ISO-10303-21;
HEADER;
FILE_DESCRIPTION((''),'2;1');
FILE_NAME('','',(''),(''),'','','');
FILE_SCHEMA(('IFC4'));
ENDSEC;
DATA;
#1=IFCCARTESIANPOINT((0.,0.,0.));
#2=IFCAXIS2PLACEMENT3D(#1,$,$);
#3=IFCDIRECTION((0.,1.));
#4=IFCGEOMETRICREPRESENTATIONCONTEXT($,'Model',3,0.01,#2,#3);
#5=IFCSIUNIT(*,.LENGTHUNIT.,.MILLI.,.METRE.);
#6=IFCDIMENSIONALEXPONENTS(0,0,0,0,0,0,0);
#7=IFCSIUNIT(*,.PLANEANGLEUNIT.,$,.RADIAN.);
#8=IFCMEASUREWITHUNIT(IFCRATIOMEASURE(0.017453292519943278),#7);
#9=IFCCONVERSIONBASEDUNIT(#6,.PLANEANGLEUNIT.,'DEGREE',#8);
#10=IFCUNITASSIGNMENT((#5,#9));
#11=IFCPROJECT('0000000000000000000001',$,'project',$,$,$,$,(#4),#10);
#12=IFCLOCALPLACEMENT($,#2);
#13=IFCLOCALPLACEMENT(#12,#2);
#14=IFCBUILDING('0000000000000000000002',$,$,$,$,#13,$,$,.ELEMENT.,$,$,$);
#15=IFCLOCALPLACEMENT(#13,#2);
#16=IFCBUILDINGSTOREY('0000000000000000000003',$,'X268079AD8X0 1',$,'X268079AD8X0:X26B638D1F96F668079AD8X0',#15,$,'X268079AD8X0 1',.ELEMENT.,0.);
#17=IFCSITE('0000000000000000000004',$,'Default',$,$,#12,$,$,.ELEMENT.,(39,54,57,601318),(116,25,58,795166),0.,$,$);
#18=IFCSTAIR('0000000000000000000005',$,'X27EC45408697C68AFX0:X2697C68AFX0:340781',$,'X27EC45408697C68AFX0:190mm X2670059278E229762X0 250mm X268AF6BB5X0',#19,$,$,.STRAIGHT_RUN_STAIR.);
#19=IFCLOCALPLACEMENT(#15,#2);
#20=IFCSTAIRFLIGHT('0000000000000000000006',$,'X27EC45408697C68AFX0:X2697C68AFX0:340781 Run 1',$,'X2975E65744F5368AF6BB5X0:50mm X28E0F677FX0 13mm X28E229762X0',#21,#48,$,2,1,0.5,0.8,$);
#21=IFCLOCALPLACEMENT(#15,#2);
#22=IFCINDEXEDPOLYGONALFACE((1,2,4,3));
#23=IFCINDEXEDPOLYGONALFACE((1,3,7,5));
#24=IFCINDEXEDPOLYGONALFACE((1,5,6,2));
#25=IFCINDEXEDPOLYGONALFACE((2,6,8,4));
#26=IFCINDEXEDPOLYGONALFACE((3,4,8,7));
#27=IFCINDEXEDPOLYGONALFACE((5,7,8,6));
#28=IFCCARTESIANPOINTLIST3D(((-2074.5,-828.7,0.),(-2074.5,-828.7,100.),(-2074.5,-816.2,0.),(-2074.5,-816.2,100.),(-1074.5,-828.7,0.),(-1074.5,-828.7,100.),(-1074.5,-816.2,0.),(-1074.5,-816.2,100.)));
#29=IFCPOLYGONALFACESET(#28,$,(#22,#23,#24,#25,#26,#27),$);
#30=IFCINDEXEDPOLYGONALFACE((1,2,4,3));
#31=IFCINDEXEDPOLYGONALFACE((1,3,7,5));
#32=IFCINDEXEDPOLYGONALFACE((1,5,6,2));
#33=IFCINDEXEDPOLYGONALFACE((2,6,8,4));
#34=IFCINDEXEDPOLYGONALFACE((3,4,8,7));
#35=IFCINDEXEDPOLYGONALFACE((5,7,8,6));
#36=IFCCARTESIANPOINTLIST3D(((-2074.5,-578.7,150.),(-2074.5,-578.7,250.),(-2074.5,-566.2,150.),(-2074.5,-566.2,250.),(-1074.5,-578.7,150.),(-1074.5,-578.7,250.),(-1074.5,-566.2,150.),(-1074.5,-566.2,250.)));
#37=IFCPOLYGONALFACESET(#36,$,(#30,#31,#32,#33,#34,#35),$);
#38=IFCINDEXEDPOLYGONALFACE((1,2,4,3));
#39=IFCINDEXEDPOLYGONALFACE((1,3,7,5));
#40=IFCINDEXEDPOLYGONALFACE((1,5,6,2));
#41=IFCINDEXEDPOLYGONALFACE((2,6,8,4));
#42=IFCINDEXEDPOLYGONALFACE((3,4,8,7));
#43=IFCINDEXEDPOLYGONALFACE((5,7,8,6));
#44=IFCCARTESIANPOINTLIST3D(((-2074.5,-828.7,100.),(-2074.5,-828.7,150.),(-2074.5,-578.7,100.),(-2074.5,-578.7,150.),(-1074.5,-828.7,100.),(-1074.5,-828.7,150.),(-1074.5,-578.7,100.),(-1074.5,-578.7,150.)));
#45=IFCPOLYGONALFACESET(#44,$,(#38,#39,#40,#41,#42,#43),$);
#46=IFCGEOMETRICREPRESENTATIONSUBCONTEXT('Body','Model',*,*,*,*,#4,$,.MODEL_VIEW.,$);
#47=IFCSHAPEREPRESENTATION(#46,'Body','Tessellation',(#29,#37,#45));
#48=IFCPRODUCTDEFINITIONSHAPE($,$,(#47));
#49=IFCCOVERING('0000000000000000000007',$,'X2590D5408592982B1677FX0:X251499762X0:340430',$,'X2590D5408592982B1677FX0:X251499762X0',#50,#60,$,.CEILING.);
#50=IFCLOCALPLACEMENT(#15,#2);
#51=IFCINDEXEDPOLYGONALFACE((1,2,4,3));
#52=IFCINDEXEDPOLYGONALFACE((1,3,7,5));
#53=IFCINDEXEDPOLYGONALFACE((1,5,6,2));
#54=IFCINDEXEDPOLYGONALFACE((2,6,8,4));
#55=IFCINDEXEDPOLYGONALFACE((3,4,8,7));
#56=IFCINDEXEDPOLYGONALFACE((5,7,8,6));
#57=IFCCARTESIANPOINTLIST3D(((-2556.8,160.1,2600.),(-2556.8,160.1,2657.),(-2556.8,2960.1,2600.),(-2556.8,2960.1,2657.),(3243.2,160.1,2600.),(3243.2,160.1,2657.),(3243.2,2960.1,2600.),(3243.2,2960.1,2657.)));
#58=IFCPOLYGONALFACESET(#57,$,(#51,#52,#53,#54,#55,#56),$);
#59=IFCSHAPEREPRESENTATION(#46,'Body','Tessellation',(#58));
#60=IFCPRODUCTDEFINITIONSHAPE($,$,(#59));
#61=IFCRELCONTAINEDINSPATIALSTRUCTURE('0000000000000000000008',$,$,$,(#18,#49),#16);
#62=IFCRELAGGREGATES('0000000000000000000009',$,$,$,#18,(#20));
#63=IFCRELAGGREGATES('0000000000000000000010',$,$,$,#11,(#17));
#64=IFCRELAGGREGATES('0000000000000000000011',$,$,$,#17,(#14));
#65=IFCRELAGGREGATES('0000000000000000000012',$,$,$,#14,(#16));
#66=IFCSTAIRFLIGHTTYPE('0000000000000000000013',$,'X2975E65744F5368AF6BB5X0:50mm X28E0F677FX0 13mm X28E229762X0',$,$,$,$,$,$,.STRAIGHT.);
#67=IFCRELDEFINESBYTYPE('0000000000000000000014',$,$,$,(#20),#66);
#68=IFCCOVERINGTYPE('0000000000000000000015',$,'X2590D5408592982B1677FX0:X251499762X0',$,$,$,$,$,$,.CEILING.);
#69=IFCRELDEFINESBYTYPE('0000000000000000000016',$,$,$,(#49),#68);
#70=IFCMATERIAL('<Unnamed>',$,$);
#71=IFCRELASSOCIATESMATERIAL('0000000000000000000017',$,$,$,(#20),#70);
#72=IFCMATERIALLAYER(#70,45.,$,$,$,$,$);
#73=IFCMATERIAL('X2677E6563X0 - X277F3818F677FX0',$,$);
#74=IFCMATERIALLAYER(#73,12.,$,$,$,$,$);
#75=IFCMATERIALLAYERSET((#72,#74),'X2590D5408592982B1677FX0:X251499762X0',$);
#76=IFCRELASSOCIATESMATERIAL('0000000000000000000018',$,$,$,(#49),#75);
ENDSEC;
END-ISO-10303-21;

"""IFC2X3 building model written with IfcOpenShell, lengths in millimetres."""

from ifc_helpers import new_model, entity, si_unit, converted_unit, direction, frame, frame_2d, origin, origin_2d_with_axis, place, context, subcontext, project, spatial, rectangle, extrude, material, layer, layer_set, layer_usage, type_object, element, aggregate, save


model = new_model("IFC2X3")

# Units and contexts
model_context = context("Model", 3, precision=0.01, world=origin(), true_north=direction((0.0, 1.0)))
body_context = subcontext(model_context, "Body", "Model", "MODEL_VIEW")
ifc_project = project(units=[si_unit("LENGTHUNIT", "METRE", prefix="MILLI"), converted_unit("PLANEANGLEUNIT", "DEGREE", entity("IfcRatioMeasure", 0.017453292519943278), si_unit("PLANEANGLEUNIT", "RADIAN"), dimensions=[0, 0, 0, 0, 0, 0, 0])], contexts=[model_context])

# Site, building, storey
site_placement = place(None, origin())
site = spatial("IfcSite", under=ifc_project, at=site_placement, Name="Default", CompositionType="ELEMENT", RefLatitude=(39, 54, 57, 601318), RefLongitude=(116, 25, 58, 795166), RefElevation=0.0)
building_placement = place(site_placement, origin())
building = spatial("IfcBuilding", under=site, at=building_placement, CompositionType="ELEMENT")
storey_placement = place(building_placement, origin())
storey = spatial("IfcBuildingStorey", under=building, at=storey_placement, Name="X268079AD8X0 1", ObjectType="X268079AD8X0:X26B638D1F96F668079AD8X0", LongName="X268079AD8X0 1", CompositionType="ELEMENT", Elevation=0.0)

# Stair
stair_placement = place(storey_placement, origin())
stair = element("IfcStair", 1, at=stair_placement, inside=storey, Name="X27EC45408697C68AFX0:X2697C68AFX0:340781", ObjectType="X27EC45408697C68AFX0:190mm X2670059278E229762X0 250mm X268AF6BB5X0", ShapeType="STRAIGHT_RUN_STAIR")
ifc_material_1 = material(Name="<Unnamed>")

# Stair flight
stair_flight_type = type_object("IfcStairFlightType", Name="X2975E65744F5368AF6BB5X0:50mm X28E0F677FX0 13mm X28E229762X0", PredefinedType="STRAIGHT")
stair_flight_placement = place(stair_placement, origin())
stair_flight = element("IfcStairFlight", 2, at=stair_flight_placement, type_object=stair_flight_type, material=ifc_material_1, Name="X27EC45408697C68AFX0:X2697C68AFX0:340781 Run 1", ObjectType="X2975E65744F5368AF6BB5X0:50mm X28E0F677FX0 13mm X28E229762X0", NumberOfRiser=2, NumberOfTreads=1, RiserHeight=0.5, TreadLength=0.8, context=body_context, shape_type="SweptSolid", body=[
    extrude(rectangle(XDim=1000.0, YDim=12.5, at=frame_2d((0.0, 0.0), x_axis=(1.0, 0.0))), frame((-1574.5, -822.5, 0.0), z_axis=(0.0, 0.0, 1.0), x_axis=(-1.0, 0.0, 0.0)), (0.0, 0.0, 1.0), 100.0),
    extrude(rectangle(XDim=1000.0, YDim=12.5, at=origin_2d_with_axis()), frame((-1574.5, -572.5, 150.0), z_axis=(0.0, 0.0, 1.0), x_axis=(-1.0, 0.0, 0.0)), (0.0, 0.0, 1.0), 100.0),
    extrude(rectangle(XDim=250.0, YDim=1000.0, at=frame_2d((0.0, 0.0), x_axis=(1.0, 0.0))), frame((-1574.5, -703.7, 100.0), z_axis=(0.0, 0.0, 1.0), x_axis=(0.0, -1.0, 0.0)), (0.0, 0.0, 1.0), 50.0),
])
aggregate(stair, [stair_flight])

# Covering
ifc_layer_1 = layer(ifc_material_1, 45.0)
ifc_material_2 = material(Name="X2677E6563X0 - X277F3818F677FX0")
ifc_layer_2 = layer(ifc_material_2, 12.0)
ifc_layer_set_1 = layer_set([ifc_layer_1, ifc_layer_2], Name="X2590D5408592982B1677FX0:X251499762X0")
ifc_layer_usage_1 = layer_usage(ifc_layer_set_1, "AXIS3", "POSITIVE", 0.0)
covering_type = type_object("IfcCoveringType", Name="X2590D5408592982B1677FX0:X251499762X0", PredefinedType="CEILING")
covering_placement = place(storey_placement, origin())
element("IfcCovering", 3, at=covering_placement, inside=storey, type_object=covering_type, material=ifc_layer_usage_1, Name="X2590D5408592982B1677FX0:X251499762X0:340430", ObjectType="X2590D5408592982B1677FX0:X251499762X0", PredefinedType="CEILING", context=body_context, shape_type="SweptSolid", body=[
    extrude(rectangle(XDim=5800.0, YDim=2800.0, at=frame_2d((0.0, 0.0), x_axis=(1.0, 0.0))), frame((343.2, 1560.1, 2600.0), z_axis=(0.0, 0.0, 1.0), x_axis=(-1.0, 0.0, 0.0)), (0.0, 0.0, 1.0), 57.0),
])

save(model, "model.ifc")
